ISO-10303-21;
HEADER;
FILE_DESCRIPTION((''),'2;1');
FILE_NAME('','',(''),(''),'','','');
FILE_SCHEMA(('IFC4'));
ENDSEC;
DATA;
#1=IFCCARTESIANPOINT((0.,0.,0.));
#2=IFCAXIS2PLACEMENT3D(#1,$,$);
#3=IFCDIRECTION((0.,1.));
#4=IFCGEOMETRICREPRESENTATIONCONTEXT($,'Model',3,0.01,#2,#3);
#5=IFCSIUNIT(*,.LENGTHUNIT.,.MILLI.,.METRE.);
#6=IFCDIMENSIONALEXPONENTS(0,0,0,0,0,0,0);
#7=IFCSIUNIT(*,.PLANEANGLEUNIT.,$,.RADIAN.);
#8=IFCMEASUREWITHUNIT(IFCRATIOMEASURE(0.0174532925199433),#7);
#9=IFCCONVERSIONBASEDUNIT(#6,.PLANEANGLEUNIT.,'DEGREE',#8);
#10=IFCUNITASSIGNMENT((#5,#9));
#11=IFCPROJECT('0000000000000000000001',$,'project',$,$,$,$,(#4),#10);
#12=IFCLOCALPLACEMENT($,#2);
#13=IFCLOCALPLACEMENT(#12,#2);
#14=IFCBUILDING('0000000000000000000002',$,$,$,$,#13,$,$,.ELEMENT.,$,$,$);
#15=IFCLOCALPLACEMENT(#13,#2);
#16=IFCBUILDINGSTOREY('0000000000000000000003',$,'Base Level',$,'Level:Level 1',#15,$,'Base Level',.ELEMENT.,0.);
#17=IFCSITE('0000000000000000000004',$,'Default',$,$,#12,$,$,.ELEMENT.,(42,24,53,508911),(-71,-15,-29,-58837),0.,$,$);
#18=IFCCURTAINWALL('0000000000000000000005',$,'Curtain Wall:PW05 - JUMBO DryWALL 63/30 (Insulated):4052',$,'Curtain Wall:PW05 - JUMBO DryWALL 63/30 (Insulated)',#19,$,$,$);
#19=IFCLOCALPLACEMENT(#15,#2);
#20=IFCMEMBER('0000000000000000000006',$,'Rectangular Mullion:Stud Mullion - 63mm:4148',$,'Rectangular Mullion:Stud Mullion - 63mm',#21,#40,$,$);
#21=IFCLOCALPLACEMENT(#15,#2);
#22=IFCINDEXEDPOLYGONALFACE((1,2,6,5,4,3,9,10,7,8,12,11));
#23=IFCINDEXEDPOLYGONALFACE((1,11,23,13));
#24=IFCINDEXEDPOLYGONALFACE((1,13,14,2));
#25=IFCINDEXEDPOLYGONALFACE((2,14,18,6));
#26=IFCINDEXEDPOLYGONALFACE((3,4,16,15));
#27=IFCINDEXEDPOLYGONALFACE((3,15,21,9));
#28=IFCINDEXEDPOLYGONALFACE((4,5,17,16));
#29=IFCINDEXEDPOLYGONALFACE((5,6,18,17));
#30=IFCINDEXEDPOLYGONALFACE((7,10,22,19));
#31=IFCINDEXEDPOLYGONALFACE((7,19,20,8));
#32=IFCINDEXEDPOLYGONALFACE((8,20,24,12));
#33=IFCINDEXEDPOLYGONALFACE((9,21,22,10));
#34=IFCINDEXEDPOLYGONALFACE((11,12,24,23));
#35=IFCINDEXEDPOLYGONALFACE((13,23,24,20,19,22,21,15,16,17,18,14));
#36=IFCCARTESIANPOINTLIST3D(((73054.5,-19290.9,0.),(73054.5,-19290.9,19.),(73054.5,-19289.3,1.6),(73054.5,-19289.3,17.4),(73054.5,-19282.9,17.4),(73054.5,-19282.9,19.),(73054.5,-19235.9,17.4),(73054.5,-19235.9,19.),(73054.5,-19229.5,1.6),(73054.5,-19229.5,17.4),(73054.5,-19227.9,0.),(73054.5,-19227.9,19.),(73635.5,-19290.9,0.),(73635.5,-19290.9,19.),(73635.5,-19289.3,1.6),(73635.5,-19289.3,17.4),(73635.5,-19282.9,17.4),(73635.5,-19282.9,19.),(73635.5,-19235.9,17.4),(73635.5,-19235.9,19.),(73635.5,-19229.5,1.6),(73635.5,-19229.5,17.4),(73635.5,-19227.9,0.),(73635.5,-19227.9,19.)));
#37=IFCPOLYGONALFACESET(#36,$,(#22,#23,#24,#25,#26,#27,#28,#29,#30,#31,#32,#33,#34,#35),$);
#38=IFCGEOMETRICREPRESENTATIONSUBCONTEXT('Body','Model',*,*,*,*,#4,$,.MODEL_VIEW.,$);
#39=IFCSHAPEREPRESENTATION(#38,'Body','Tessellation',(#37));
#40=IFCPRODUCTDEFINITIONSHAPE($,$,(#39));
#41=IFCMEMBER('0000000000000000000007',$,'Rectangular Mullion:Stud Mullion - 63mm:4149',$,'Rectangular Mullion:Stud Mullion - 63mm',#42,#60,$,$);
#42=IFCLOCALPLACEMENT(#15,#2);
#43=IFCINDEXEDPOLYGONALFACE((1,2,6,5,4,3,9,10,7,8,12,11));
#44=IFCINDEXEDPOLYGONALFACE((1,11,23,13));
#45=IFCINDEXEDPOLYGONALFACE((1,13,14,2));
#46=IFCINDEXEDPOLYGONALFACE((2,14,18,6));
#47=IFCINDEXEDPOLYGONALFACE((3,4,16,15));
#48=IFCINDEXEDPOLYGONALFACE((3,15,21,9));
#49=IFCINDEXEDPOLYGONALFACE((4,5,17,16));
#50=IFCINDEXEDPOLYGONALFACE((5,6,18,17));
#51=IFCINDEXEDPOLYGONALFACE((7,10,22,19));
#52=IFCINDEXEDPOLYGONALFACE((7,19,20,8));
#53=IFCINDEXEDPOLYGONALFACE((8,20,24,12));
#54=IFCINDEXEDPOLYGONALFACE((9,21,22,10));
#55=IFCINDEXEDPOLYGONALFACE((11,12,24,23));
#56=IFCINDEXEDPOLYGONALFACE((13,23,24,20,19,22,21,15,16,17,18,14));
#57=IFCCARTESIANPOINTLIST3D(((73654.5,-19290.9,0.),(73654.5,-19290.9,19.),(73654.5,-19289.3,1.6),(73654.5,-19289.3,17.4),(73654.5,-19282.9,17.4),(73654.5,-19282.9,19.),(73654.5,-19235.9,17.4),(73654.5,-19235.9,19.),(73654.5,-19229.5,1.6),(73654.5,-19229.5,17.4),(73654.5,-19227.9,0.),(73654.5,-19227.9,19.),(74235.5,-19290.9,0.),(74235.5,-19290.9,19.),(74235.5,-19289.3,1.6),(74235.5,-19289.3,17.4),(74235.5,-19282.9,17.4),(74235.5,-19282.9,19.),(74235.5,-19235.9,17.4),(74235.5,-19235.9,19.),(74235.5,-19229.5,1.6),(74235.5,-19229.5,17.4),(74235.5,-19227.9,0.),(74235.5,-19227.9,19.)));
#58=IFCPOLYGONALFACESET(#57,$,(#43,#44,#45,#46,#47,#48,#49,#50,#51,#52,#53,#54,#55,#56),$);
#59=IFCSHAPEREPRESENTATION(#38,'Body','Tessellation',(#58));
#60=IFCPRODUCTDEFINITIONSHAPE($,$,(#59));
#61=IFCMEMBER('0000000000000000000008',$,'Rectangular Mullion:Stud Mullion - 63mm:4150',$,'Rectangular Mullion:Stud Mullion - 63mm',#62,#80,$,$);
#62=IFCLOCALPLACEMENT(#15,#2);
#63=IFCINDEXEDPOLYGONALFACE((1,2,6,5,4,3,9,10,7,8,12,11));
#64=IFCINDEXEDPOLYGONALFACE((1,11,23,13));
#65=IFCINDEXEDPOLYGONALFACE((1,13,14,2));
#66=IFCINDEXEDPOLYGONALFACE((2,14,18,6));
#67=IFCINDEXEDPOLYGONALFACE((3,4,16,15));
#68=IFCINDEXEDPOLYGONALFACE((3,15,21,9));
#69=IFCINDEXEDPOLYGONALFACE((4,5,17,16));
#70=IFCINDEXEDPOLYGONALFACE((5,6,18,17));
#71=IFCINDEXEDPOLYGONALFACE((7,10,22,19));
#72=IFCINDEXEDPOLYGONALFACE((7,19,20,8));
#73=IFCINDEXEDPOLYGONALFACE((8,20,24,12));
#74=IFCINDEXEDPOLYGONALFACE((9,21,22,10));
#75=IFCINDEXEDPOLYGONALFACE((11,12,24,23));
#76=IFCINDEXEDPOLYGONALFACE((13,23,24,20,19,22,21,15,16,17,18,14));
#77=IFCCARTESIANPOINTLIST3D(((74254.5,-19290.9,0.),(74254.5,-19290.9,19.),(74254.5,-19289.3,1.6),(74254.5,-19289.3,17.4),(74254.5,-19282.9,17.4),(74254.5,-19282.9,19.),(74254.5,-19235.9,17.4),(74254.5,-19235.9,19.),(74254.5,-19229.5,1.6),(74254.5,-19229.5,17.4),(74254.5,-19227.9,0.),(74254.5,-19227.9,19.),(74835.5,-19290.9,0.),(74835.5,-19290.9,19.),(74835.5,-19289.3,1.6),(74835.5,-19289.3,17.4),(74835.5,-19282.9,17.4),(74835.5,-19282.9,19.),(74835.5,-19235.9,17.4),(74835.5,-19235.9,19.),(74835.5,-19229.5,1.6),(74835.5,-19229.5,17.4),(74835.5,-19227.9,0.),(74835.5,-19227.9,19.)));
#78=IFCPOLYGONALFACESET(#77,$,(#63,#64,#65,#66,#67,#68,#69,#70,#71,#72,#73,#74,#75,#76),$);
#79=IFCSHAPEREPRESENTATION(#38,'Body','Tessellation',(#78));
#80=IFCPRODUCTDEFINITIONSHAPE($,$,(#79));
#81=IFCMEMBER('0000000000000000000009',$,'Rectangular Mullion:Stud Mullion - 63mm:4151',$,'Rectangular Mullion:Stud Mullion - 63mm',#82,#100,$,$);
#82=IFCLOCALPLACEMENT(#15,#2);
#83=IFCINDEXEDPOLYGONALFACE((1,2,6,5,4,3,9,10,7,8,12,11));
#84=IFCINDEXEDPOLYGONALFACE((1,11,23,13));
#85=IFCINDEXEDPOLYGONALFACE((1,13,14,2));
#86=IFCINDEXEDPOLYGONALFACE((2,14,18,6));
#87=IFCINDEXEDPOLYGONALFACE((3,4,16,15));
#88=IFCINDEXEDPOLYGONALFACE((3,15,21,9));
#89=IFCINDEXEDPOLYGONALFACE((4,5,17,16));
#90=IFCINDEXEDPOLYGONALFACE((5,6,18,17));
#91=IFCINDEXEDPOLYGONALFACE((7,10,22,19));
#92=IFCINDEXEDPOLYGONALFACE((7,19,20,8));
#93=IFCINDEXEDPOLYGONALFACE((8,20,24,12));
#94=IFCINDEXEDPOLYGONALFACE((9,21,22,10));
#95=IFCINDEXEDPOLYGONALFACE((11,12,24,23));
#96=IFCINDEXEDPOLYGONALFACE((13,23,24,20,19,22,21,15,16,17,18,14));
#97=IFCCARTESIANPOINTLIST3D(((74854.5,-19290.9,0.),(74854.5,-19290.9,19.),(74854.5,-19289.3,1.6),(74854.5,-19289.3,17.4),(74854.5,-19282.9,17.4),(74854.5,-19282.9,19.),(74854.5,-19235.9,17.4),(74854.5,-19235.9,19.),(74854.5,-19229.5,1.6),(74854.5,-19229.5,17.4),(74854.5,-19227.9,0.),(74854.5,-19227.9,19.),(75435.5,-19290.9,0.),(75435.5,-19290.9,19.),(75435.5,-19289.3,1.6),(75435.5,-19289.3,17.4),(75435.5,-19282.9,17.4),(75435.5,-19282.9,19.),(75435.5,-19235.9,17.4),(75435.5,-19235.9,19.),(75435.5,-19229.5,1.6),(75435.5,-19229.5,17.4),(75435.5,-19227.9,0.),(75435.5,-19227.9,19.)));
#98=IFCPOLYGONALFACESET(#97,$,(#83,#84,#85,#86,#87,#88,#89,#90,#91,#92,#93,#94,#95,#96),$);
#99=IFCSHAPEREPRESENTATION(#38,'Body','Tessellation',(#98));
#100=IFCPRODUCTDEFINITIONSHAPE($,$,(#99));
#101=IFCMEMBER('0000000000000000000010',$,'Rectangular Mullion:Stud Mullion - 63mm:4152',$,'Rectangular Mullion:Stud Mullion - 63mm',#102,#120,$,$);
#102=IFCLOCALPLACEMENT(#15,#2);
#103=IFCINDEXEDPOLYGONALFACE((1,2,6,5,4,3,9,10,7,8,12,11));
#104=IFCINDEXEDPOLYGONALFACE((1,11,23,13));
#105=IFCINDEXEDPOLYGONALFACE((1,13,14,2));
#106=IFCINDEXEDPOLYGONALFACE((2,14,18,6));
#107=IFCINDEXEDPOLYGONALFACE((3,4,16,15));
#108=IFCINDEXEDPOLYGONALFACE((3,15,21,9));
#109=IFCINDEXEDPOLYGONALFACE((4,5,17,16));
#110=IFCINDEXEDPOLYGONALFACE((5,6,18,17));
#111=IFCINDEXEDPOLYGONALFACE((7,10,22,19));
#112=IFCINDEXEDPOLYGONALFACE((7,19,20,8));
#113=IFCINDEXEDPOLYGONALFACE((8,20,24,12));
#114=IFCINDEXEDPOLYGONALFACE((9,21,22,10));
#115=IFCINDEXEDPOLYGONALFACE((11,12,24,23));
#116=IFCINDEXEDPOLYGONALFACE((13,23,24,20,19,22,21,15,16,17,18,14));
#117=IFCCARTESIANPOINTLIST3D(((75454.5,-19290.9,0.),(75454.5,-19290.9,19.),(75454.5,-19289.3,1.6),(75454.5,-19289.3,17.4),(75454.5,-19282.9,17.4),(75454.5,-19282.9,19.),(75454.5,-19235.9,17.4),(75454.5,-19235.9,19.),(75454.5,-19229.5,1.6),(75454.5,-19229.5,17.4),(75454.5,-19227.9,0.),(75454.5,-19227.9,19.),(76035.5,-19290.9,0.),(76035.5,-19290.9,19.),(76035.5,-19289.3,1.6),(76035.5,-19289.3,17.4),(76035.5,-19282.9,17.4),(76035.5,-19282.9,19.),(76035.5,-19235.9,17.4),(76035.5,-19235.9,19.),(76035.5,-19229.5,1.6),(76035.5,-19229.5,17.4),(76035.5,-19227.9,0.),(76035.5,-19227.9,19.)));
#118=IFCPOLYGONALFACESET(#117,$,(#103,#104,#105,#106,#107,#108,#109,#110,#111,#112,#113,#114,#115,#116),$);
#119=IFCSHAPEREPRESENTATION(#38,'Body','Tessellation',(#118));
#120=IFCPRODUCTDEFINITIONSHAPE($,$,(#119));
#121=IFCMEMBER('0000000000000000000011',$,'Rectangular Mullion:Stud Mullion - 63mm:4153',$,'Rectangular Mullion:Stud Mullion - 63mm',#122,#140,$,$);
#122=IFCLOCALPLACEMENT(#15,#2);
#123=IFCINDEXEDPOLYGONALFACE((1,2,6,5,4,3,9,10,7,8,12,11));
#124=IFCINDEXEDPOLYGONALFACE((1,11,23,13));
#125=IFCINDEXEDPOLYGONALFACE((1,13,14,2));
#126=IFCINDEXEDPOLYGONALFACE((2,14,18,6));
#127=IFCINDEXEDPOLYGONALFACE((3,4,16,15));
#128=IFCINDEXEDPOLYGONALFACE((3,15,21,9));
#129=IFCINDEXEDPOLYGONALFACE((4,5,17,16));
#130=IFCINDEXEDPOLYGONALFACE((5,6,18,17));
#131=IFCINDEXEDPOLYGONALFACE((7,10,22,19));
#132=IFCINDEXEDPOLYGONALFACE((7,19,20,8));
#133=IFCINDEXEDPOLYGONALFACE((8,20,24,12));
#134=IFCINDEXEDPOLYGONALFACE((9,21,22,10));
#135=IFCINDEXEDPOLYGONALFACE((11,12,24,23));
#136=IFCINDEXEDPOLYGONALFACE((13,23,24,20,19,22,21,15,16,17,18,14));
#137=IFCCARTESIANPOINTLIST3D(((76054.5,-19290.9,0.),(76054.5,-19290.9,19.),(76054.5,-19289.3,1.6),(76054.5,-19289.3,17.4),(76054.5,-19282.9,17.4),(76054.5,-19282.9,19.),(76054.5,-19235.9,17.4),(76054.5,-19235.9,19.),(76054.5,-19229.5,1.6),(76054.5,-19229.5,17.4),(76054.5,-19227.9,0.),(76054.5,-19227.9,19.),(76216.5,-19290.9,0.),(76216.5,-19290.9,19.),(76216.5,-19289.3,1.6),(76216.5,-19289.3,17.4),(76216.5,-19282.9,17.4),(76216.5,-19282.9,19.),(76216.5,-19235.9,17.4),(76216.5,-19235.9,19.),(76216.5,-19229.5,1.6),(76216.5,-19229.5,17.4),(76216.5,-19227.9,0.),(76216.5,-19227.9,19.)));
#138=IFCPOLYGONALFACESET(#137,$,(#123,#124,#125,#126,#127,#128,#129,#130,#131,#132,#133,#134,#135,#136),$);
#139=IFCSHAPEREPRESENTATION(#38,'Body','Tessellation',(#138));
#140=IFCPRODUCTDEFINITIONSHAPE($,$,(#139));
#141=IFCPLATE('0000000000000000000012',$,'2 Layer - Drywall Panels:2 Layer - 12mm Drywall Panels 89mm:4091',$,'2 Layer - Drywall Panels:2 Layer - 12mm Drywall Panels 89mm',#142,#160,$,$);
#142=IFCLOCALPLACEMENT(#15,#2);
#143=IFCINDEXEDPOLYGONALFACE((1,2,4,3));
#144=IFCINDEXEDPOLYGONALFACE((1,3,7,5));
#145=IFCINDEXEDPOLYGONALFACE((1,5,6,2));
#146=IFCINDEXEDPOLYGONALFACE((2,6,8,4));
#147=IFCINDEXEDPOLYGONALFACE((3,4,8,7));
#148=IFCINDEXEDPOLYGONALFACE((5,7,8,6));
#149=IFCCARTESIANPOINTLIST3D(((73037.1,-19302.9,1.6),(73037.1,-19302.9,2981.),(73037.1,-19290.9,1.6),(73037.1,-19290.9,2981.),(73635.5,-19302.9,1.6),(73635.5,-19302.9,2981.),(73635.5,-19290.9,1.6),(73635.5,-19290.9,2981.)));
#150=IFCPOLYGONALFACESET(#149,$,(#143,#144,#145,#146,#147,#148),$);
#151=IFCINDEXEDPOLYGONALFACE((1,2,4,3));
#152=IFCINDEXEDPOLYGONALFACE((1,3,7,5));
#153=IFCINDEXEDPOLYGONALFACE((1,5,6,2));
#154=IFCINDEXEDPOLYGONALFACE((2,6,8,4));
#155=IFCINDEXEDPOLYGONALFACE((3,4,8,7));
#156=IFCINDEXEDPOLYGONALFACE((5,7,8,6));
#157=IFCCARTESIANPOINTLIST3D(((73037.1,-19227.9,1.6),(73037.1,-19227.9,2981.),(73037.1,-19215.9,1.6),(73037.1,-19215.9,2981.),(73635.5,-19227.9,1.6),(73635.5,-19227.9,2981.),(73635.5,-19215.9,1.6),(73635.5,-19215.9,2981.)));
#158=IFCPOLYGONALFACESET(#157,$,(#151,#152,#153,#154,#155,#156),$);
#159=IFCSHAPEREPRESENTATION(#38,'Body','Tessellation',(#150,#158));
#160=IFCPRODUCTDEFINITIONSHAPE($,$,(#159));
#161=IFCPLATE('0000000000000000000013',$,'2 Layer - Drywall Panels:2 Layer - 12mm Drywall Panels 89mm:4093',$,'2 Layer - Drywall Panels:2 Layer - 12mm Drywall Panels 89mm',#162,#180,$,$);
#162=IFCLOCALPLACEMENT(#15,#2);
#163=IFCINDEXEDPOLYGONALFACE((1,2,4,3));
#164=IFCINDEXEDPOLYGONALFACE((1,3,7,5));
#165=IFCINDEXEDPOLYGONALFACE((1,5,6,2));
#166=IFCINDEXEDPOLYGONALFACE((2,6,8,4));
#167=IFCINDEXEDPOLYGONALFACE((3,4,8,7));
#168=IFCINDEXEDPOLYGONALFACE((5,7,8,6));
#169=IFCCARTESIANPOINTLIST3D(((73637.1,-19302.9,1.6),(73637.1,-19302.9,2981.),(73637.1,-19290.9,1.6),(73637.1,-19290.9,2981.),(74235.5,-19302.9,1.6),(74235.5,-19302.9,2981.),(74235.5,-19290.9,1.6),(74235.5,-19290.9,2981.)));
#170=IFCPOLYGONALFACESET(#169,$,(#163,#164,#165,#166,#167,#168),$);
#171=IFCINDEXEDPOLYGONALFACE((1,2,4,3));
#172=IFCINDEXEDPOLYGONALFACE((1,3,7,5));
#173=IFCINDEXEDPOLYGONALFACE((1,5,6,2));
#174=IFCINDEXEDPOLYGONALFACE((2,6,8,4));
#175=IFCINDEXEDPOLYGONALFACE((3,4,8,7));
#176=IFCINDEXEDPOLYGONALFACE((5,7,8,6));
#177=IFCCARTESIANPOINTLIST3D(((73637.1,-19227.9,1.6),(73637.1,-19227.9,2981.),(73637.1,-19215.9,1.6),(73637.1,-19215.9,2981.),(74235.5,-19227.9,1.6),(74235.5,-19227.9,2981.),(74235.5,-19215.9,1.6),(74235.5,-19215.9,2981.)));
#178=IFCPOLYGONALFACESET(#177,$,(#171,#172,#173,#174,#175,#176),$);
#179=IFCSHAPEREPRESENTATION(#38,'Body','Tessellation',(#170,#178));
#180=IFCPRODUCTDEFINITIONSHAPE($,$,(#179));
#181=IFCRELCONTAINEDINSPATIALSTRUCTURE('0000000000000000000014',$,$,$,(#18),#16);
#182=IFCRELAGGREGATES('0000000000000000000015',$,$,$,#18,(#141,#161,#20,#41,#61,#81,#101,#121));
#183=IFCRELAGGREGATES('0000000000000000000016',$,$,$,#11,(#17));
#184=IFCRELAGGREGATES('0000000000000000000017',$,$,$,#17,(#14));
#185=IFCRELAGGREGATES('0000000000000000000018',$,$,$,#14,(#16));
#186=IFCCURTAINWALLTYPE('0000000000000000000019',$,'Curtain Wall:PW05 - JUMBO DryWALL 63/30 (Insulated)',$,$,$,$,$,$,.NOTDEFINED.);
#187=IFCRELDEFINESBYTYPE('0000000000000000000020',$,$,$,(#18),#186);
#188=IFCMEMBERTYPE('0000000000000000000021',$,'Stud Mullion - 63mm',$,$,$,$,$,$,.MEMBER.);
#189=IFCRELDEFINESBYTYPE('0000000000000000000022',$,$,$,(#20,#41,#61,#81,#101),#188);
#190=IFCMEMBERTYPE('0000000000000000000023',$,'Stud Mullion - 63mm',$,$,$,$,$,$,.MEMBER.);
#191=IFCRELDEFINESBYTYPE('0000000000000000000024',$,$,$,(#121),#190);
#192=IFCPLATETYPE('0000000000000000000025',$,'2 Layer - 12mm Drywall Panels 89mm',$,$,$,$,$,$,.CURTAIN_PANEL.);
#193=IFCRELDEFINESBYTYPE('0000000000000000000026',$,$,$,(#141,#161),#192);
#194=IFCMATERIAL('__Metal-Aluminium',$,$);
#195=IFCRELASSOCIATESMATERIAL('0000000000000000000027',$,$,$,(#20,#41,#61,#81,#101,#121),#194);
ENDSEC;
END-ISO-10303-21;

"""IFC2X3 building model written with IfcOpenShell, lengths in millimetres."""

from ifc_helpers import new_model, entity, si_unit, converted_unit, direction, frame, frame_2d, origin, place, context, subcontext, project, spatial, polyline, rectangle, outline, extrude, source, transform, mapped, material, type_object, type_shapes, element, aggregate, save


model = new_model("IFC2X3")

# Units and contexts
model_context = context("Model", 3, precision=0.01, world=origin(), true_north=direction((0.0, 1.0)))
body_context = subcontext(model_context, "Body", "Model", "MODEL_VIEW")
ifc_project = project(units=[si_unit("LENGTHUNIT", "METRE", prefix="MILLI"), converted_unit("PLANEANGLEUNIT", "DEGREE", entity("IfcRatioMeasure", 0.0174532925199433), si_unit("PLANEANGLEUNIT", "RADIAN"), dimensions=[0, 0, 0, 0, 0, 0, 0])], contexts=[model_context])

# Site, building, storey
site_placement = place(None, origin())
site = spatial("IfcSite", under=ifc_project, at=site_placement, Name="Default", CompositionType="ELEMENT", RefLatitude=(42, 24, 53, 508911), RefLongitude=(-71, -15, -29, -58837), RefElevation=0.0)
building_placement = place(site_placement, origin())
building = spatial("IfcBuilding", under=site, at=building_placement, CompositionType="ELEMENT")
storey_placement = place(building_placement, origin())
storey = spatial("IfcBuildingStorey", under=building, at=storey_placement, Name="Base Level", ObjectType="Level:Level 1", LongName="Base Level", CompositionType="ELEMENT", Elevation=0.0)

# Curtain wall, members, plates
curtain_wall_type = type_object("IfcCurtainWallType", Name="Curtain Wall:PW05 - JUMBO DryWALL 63/30 (Insulated)", PredefinedType="NOTDEFINED")
curtain_wall_placement = place(building_placement, origin())
curtain_wall = element("IfcCurtainWall", 1, at=curtain_wall_placement, inside=storey, type_object=curtain_wall_type, Name="Curtain Wall:PW05 - JUMBO DryWALL 63/30 (Insulated):4052", ObjectType="Curtain Wall:PW05 - JUMBO DryWALL 63/30 (Insulated)")
ifc_material = material(Name="__Metal-Aluminium")
member_type_1 = type_object("IfcMemberType", Name="Stud Mullion - 63mm", PredefinedType="MEMBER")
shared_shape_1 = source(origin(), body_context, "Body", "SweptSolid", [
    extrude(outline(polyline([(23.5, -6.6), (31.5, -6.6), (31.5, 12.4), (-31.5, 12.4), (-31.5, -6.6), (-23.5, -6.6), (-23.5, -5.0), (-29.9, -5.0), (-29.9, 10.8), (29.9, 10.8), (29.9, -5.0), (23.5, -5.0), (23.5, -6.6)])), frame((-12.4, 0.0, -581.0), z_axis=(0.0, 0.0, 1.0), x_axis=(0.0, -1.0, 0.0)), (0.0, 0.0, 1.0), 581.0),
])
type_shapes(member_type_1, [shared_shape_1])
member_1_placement = place(building_placement, frame((73054.5, -19259.4, 0.0), z_axis=(-1.0, 0.0, 0.0), x_axis=(0.0, 0.0, -1.0)))
member_1 = element("IfcMember", 2, at=member_1_placement, type_object=member_type_1, material=ifc_material, Name="Rectangular Mullion:Stud Mullion - 63mm:4148", ObjectType="Rectangular Mullion:Stud Mullion - 63mm", context=body_context, shape_type="MappedRepresentation", body=[
    mapped(shared_shape_1, transform((0.0, 0.0, 0.0), scale=1.0)),
])
member_2_placement = place(building_placement, frame((73654.5, -19259.4, 0.0), z_axis=(-1.0, 0.0, 0.0), x_axis=(0.0, 0.0, -1.0)))
member_2 = element("IfcMember", 3, at=member_2_placement, type_object=member_type_1, material=ifc_material, Name="Rectangular Mullion:Stud Mullion - 63mm:4149", ObjectType="Rectangular Mullion:Stud Mullion - 63mm", context=body_context, shape_type="MappedRepresentation", body=[
    mapped(shared_shape_1, transform((0.0, 0.0, 0.0), scale=1.0)),
])
member_3_placement = place(building_placement, frame((74254.5, -19259.4, 0.0), z_axis=(-1.0, 0.0, 0.0), x_axis=(0.0, 0.0, -1.0)))
member_3 = element("IfcMember", 4, at=member_3_placement, type_object=member_type_1, material=ifc_material, Name="Rectangular Mullion:Stud Mullion - 63mm:4150", ObjectType="Rectangular Mullion:Stud Mullion - 63mm", context=body_context, shape_type="MappedRepresentation", body=[
    mapped(shared_shape_1, transform((0.0, 0.0, 0.0), scale=1.0)),
])
member_4_placement = place(building_placement, frame((74854.5, -19259.4, 0.0), z_axis=(-1.0, 0.0, 0.0), x_axis=(0.0, 0.0, -1.0)))
member_4 = element("IfcMember", 5, at=member_4_placement, type_object=member_type_1, material=ifc_material, Name="Rectangular Mullion:Stud Mullion - 63mm:4151", ObjectType="Rectangular Mullion:Stud Mullion - 63mm", context=body_context, shape_type="MappedRepresentation", body=[
    mapped(shared_shape_1, transform((0.0, 0.0, 0.0), scale=1.0)),
])
member_5_placement = place(building_placement, frame((75454.5, -19259.4, 0.0), z_axis=(-1.0, 0.0, 0.0), x_axis=(0.0, 0.0, -1.0)))
member_5 = element("IfcMember", 6, at=member_5_placement, type_object=member_type_1, material=ifc_material, Name="Rectangular Mullion:Stud Mullion - 63mm:4152", ObjectType="Rectangular Mullion:Stud Mullion - 63mm", context=body_context, shape_type="MappedRepresentation", body=[
    mapped(shared_shape_1, transform((0.0, 0.0, 0.0), scale=1.0)),
])
member_type_2 = type_object("IfcMemberType", Name="Stud Mullion - 63mm", PredefinedType="MEMBER")
shared_shape_2 = source(origin(), body_context, "Body", "SweptSolid", [
    extrude(outline(polyline([(23.5, -6.6), (31.5, -6.6), (31.5, 12.4), (-31.5, 12.4), (-31.5, -6.6), (-23.5, -6.6), (-23.5, -5.0), (-29.9, -5.0), (-29.9, 10.8), (29.9, 10.8), (29.9, -5.0), (23.5, -5.0), (23.5, -6.6)])), frame((-12.4, 0.0, -162.0), z_axis=(0.0, 0.0, 1.0), x_axis=(0.0, -1.0, 0.0)), (0.0, 0.0, 1.0), 162.0),
])
type_shapes(member_type_2, [shared_shape_2])
member_6_placement = place(building_placement, frame((76054.5, -19259.4, 0.0), z_axis=(-1.0, 0.0, 0.0), x_axis=(0.0, 0.0, -1.0)))
member_6 = element("IfcMember", 7, at=member_6_placement, type_object=member_type_2, material=ifc_material, Name="Rectangular Mullion:Stud Mullion - 63mm:4153", ObjectType="Rectangular Mullion:Stud Mullion - 63mm", context=body_context, shape_type="MappedRepresentation", body=[
    mapped(shared_shape_2, transform((0.0, 0.0, 0.0), scale=1.0)),
])
plate_type_1 = type_object("IfcPlateType", Name="2 Layer - 12mm Drywall Panels 89mm", PredefinedType="CURTAIN_PANEL")
shared_shape_3 = source(origin(), body_context, "Body", "SweptSolid", [
    extrude(rectangle(XDim=598.4, YDim=12.0, at=frame_2d((0.0, 0.0), x_axis=(1.0, 0.0))), frame((0.0, -37.5, 0.0), z_axis=(0.0, 0.0, 1.0), x_axis=(-1.0, 0.0, 0.0)), (0.0, 0.0, 1.0), 2979.4),
    extrude(rectangle(XDim=12.0, YDim=598.4, at=frame_2d((0.0, 0.0), x_axis=(1.0, 0.0))), frame((0.0, 37.5, 0.0), z_axis=(0.0, 0.0, 1.0), x_axis=(0.0, 1.0, 0.0)), (0.0, 0.0, 1.0), 2979.4),
])
type_shapes(plate_type_1, [shared_shape_3])
plate_1_placement = place(curtain_wall_placement, frame((73336.3, -19259.4, 1.6)))
plate_1 = element("IfcPlate", 8, at=plate_1_placement, type_object=plate_type_1, Name="2 Layer - Drywall Panels:2 Layer - 12mm Drywall Panels 89mm:4091", ObjectType="2 Layer - Drywall Panels:2 Layer - 12mm Drywall Panels 89mm", context=body_context, shape_type="MappedRepresentation", body=[
    mapped(shared_shape_3, transform((0.0, 0.0, 0.0), scale=1.0)),
])
plate_2_placement = place(curtain_wall_placement, frame((73936.3, -19259.4, 1.6)))
plate_2 = element("IfcPlate", 9, at=plate_2_placement, type_object=plate_type_1, Name="2 Layer - Drywall Panels:2 Layer - 12mm Drywall Panels 89mm:4093", ObjectType="2 Layer - Drywall Panels:2 Layer - 12mm Drywall Panels 89mm", context=body_context, shape_type="MappedRepresentation", body=[
    mapped(shared_shape_3, transform((0.0, 0.0, 0.0), scale=1.0)),
])
aggregate(curtain_wall, [plate_1, plate_2, member_1, member_2, member_3, member_4, member_5, member_6])

save(model, "model.ifc")
